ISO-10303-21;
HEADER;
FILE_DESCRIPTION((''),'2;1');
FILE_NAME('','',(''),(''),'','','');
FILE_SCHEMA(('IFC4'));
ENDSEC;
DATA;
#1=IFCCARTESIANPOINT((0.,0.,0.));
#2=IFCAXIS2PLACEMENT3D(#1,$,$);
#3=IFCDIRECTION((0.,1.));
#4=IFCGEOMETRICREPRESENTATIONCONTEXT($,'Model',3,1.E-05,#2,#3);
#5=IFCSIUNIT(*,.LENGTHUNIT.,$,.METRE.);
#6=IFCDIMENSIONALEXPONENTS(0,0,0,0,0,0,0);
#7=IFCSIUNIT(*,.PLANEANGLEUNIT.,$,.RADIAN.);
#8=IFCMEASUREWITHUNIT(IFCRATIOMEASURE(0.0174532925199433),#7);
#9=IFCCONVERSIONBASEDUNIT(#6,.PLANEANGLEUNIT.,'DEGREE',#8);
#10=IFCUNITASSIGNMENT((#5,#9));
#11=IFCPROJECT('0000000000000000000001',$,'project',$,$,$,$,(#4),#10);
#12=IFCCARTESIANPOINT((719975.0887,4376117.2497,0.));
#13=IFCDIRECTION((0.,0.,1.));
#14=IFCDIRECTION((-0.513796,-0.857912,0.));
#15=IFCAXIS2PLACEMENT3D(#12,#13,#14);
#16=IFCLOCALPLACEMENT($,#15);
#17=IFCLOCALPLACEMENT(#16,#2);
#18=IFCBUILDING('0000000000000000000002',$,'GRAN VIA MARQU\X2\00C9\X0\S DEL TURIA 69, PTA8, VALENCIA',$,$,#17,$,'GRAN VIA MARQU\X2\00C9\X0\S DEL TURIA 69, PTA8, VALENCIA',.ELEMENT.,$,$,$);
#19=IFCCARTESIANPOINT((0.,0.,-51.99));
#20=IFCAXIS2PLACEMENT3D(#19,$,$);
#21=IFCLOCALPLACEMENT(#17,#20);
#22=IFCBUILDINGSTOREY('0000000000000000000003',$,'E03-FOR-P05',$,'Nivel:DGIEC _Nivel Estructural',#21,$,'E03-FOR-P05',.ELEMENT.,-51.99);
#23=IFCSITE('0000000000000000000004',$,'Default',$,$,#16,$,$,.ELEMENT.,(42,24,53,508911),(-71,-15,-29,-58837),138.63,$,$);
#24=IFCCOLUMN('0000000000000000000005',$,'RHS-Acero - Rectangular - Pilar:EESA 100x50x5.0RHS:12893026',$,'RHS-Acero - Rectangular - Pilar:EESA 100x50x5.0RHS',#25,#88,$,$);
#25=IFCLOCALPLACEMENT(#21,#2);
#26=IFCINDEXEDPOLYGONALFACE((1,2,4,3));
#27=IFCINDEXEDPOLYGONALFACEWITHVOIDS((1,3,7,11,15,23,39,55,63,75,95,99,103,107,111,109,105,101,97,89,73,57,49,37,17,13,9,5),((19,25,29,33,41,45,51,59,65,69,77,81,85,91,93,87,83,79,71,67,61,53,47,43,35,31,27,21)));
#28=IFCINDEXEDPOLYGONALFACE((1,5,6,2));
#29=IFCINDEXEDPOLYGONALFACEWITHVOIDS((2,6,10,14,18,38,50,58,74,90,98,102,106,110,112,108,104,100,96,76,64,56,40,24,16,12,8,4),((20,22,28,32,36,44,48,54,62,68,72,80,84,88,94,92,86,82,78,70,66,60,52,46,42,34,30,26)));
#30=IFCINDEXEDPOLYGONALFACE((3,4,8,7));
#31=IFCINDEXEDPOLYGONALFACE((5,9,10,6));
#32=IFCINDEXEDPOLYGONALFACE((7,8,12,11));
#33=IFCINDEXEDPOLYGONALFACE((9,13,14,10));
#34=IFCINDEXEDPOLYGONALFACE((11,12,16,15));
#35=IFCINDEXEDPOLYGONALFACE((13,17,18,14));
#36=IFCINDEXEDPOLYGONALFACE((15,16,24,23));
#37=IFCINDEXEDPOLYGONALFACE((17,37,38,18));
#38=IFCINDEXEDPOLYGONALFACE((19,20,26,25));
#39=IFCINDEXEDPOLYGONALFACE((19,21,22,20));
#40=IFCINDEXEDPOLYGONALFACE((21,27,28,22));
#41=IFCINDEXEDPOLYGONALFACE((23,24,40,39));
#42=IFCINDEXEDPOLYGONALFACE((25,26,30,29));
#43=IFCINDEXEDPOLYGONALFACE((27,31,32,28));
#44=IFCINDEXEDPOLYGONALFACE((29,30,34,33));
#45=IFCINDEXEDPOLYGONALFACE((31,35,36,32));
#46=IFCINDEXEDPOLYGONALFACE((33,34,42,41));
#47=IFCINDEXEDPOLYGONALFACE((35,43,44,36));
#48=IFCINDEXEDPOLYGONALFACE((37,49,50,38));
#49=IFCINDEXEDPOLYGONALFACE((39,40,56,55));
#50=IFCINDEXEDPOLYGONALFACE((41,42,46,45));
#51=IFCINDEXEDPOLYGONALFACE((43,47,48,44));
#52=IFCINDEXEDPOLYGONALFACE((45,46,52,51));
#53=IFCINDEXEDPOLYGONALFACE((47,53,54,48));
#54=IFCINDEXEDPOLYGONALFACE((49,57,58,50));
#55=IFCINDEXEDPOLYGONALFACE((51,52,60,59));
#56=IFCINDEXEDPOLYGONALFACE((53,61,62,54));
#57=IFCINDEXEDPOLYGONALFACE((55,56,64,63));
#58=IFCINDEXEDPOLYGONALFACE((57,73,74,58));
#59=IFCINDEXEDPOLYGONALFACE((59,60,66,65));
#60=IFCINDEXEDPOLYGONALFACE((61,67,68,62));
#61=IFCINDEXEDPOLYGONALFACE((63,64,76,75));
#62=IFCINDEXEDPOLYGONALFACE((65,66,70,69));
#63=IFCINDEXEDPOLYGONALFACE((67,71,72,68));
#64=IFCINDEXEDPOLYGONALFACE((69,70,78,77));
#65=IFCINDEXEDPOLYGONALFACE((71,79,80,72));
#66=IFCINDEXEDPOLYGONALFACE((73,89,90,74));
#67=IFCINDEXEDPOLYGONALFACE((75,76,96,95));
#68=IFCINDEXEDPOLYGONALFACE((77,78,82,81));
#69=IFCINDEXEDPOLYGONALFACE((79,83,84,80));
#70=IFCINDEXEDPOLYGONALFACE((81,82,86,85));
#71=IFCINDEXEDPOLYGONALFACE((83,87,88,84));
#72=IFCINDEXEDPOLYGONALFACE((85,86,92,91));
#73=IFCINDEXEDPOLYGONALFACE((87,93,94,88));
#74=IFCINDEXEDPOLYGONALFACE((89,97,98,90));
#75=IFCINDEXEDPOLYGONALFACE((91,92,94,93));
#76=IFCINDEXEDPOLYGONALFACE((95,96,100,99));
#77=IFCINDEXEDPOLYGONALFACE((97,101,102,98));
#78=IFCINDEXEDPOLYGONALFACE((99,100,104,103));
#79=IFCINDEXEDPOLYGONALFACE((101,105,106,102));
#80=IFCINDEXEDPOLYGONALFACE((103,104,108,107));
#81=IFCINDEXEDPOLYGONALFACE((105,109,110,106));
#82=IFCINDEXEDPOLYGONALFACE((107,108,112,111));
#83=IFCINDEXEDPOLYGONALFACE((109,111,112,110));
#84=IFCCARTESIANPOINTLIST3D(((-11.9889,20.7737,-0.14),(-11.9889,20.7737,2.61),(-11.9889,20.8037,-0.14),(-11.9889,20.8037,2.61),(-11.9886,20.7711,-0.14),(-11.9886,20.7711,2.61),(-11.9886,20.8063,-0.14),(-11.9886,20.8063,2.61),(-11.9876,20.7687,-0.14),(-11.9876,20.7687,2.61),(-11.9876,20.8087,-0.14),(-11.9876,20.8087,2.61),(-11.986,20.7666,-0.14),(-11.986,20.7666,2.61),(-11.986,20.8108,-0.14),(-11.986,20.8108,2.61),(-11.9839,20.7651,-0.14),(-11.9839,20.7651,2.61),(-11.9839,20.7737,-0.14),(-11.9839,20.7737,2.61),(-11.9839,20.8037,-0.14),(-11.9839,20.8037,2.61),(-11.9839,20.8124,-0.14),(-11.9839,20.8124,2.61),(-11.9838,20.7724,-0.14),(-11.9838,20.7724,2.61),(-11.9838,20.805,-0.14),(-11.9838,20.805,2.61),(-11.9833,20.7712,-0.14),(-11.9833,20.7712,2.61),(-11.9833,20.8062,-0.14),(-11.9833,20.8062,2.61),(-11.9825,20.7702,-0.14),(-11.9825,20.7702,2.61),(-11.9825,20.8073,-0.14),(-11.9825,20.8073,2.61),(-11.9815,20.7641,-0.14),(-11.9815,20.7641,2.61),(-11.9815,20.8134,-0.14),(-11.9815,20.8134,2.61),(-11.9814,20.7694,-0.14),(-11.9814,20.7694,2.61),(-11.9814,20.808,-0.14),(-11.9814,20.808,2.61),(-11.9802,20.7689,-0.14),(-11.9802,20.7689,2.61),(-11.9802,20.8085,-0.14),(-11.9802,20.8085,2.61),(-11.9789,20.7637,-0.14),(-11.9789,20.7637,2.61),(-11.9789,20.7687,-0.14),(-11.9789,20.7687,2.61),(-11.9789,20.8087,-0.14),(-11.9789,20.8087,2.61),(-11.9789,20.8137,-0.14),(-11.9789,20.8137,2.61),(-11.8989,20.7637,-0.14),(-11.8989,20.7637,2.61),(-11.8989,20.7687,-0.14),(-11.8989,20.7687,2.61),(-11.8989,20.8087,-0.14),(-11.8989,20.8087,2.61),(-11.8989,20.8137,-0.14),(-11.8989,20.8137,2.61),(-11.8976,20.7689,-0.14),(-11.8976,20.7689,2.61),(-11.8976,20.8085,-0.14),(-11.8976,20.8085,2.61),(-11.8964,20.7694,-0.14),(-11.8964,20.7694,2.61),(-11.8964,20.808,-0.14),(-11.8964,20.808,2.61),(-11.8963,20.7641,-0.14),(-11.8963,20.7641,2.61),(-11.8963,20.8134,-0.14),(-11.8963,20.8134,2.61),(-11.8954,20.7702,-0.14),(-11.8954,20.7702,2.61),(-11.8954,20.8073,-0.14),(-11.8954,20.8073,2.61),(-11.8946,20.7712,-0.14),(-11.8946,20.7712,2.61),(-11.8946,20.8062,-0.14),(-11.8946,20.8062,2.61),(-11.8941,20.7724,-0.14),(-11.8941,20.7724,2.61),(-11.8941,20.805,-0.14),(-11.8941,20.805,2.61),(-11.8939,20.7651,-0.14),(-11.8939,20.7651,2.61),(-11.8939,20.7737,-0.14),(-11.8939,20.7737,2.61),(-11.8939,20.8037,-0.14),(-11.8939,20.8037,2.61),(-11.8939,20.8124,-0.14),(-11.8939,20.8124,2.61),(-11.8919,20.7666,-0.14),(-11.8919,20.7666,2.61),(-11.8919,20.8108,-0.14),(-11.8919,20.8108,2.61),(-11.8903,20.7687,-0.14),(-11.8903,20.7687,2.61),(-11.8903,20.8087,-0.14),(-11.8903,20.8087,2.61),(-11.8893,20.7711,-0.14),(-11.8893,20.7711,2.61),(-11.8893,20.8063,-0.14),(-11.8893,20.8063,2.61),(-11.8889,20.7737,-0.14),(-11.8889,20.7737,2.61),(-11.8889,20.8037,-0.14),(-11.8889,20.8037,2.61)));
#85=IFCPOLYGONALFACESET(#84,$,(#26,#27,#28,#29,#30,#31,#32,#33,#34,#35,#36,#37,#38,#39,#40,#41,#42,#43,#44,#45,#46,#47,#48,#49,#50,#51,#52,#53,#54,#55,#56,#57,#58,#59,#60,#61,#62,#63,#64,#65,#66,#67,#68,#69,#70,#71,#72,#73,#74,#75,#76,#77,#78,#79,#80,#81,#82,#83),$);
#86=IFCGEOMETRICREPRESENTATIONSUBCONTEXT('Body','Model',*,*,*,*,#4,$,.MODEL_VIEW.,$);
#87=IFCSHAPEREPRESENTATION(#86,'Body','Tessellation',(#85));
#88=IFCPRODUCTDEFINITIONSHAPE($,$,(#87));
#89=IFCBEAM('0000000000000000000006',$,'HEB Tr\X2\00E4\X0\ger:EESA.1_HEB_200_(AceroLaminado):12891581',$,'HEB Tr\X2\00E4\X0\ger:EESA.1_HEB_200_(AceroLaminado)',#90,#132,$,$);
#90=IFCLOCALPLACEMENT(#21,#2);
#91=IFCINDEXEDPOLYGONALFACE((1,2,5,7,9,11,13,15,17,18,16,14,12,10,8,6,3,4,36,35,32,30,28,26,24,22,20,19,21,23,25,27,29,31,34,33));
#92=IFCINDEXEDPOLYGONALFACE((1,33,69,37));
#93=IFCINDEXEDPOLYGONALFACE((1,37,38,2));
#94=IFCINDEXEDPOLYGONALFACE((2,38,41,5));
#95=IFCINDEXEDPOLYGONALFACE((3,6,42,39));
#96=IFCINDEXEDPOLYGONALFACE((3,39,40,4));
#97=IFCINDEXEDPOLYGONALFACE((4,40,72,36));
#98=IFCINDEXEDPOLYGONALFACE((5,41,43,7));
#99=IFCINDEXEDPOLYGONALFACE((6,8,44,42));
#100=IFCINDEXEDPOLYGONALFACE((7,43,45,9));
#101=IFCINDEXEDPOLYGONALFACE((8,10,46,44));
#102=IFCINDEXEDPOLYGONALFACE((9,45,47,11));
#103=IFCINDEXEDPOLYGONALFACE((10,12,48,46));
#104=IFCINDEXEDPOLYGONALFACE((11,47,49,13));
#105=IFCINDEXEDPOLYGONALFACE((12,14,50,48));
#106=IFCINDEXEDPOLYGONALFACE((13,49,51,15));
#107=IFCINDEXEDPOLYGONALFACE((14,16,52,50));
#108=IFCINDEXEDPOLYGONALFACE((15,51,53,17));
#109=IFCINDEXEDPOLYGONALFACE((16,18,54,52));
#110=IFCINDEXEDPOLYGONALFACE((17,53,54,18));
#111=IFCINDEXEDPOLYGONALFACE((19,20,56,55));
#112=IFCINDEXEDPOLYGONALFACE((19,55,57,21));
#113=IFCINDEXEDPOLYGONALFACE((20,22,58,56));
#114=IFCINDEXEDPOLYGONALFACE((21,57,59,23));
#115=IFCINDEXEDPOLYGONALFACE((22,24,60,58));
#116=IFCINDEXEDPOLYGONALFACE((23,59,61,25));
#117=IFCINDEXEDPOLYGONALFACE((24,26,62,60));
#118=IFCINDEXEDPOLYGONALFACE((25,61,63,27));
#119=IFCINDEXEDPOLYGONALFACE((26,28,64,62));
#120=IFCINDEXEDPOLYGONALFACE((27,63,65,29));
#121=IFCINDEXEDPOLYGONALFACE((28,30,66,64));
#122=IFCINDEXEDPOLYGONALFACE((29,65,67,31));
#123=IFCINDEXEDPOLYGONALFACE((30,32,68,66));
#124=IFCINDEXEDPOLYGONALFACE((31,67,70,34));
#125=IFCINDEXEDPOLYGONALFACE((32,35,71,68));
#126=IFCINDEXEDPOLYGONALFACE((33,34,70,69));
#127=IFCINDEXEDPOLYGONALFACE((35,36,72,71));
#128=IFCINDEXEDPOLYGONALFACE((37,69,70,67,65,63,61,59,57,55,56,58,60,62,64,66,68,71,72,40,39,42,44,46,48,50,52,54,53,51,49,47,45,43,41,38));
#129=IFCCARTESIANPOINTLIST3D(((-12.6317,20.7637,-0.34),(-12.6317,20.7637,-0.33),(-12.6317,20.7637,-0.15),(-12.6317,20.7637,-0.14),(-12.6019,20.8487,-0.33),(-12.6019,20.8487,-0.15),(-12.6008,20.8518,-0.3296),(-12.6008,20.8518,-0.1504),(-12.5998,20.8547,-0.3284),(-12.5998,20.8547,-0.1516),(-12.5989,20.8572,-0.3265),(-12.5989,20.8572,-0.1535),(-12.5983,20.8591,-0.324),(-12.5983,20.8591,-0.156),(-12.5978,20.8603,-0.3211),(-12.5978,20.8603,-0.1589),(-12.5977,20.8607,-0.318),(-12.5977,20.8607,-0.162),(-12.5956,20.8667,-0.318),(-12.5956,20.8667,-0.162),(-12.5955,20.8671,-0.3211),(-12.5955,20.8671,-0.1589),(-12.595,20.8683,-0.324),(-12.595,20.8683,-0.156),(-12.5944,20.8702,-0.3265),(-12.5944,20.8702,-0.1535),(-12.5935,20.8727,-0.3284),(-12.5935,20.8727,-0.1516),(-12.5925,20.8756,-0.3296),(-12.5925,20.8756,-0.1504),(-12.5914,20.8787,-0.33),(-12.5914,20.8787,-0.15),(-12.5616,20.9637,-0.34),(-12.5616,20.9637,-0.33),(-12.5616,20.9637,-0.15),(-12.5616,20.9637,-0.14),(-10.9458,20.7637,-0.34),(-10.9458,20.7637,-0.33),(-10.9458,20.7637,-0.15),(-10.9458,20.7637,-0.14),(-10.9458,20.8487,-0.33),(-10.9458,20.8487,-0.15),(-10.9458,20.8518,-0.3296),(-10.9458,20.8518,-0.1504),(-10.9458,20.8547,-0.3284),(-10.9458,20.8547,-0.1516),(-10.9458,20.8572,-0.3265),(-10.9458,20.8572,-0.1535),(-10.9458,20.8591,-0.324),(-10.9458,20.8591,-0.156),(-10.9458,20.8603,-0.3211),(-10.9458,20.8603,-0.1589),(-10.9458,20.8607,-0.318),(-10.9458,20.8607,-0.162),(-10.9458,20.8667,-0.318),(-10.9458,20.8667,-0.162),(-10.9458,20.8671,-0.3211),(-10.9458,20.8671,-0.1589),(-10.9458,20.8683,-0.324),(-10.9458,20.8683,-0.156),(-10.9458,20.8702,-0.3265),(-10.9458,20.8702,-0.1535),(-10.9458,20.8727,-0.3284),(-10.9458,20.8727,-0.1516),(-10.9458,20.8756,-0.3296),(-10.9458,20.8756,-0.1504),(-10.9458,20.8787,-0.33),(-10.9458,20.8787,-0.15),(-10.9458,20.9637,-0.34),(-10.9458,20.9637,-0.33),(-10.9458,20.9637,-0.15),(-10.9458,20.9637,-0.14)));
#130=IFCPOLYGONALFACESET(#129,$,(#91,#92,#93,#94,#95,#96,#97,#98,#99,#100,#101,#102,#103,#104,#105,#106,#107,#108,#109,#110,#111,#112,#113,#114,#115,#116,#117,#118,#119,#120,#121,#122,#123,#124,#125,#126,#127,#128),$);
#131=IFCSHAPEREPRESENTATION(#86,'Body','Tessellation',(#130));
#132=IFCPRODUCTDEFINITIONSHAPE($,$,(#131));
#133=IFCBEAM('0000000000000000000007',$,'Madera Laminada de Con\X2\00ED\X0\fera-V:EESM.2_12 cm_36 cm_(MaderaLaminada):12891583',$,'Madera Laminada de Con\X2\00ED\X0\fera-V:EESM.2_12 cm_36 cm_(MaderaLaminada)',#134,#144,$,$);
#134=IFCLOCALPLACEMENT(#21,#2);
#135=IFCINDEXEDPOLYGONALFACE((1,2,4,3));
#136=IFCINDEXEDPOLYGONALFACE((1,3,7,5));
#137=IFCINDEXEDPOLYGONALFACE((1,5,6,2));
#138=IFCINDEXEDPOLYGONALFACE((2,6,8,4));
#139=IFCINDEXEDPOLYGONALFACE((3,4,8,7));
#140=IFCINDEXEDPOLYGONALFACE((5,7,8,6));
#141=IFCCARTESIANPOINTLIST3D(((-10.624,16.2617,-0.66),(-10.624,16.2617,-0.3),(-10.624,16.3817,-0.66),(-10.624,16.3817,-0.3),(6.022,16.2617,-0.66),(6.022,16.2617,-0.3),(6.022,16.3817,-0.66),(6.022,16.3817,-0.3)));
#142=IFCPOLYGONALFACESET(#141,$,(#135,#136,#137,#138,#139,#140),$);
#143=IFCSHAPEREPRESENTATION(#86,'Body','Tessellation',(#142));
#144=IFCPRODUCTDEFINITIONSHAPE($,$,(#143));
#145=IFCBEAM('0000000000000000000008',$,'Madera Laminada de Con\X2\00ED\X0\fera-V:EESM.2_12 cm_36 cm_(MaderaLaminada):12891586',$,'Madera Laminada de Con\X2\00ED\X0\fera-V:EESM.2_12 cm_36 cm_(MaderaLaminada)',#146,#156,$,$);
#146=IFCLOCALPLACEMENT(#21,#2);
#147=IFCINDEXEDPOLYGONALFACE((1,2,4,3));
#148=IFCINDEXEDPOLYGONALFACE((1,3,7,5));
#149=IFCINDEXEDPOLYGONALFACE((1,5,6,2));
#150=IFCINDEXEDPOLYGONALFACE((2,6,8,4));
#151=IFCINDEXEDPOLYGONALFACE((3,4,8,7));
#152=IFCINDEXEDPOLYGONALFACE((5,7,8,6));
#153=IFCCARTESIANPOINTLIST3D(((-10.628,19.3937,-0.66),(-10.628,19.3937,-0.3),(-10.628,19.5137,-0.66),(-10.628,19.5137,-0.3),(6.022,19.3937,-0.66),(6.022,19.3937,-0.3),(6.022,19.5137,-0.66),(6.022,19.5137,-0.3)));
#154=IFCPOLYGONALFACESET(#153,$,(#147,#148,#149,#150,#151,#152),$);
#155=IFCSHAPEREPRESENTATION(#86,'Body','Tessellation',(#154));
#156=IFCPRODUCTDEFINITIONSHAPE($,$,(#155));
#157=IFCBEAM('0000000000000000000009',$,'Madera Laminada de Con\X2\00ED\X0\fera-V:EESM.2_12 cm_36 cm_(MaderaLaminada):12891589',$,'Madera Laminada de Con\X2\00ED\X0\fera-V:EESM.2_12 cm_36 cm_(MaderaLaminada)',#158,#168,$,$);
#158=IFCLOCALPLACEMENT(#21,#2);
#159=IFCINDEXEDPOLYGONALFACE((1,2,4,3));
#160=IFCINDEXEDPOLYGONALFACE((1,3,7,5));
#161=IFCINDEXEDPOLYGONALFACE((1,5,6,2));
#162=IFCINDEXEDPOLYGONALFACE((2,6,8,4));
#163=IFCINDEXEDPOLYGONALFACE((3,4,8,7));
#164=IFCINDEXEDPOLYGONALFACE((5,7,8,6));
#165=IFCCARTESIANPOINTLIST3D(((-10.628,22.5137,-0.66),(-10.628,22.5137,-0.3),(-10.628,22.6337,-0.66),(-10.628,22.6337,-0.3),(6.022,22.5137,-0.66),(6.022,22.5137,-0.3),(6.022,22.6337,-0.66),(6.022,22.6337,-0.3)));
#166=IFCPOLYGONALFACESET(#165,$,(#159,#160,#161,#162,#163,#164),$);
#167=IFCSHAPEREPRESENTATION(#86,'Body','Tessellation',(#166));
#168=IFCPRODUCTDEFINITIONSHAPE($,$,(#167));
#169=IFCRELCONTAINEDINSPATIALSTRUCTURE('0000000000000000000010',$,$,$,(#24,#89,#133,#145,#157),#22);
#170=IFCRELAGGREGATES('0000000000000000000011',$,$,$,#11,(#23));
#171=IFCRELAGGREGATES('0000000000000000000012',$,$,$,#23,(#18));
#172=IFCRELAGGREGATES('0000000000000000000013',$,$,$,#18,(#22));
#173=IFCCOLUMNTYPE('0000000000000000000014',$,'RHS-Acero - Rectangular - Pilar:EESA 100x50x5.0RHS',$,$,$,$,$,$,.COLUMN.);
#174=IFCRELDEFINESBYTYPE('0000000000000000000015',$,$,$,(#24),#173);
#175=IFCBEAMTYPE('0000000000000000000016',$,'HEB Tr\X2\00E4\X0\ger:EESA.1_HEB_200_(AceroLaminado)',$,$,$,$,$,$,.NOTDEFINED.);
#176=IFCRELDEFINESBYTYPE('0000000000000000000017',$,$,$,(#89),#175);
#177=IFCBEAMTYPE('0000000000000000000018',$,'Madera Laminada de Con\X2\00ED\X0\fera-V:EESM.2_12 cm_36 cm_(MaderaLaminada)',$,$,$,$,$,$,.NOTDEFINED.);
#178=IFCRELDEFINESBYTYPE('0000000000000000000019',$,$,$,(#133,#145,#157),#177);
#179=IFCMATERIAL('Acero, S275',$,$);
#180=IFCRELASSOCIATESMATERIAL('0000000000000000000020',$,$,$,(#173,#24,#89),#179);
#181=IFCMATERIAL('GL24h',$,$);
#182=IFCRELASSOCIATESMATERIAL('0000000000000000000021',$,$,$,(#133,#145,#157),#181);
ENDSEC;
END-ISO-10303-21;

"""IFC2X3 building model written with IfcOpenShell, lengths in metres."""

from ifc_helpers import new_model, entity, si_unit, converted_unit, direction, frame, frame_2d, origin, place, context, subcontext, project, spatial, polyline, circle_curve, parameter, trimmed, segment, composite_curve, rectangle, i_section, outline, extrude, clip, halfspace, source, transform, mapped, material, type_object, type_shapes, element, save


model = new_model("IFC2X3")

# Units and contexts
model_context = context("Model", 3, precision=1e-05, world=origin(), true_north=direction((0.0, 1.0)))
body_context = subcontext(model_context, "Body", "Model", "MODEL_VIEW")
ifc_project = project(units=[si_unit("LENGTHUNIT", "METRE"), converted_unit("PLANEANGLEUNIT", "DEGREE", entity("IfcRatioMeasure", 0.0174532925199433), si_unit("PLANEANGLEUNIT", "RADIAN"), dimensions=[0, 0, 0, 0, 0, 0, 0])], contexts=[model_context])

# Site, building, storey
site_placement = place(None, frame((719975.0887, 4376117.2497, 0.0), z_axis=(0.0, 0.0, 1.0), x_axis=(-0.513796, -0.857912, 0.0)))
site = spatial("IfcSite", under=ifc_project, at=site_placement, Name="Default", CompositionType="ELEMENT", RefLatitude=(42, 24, 53, 508911), RefLongitude=(-71, -15, -29, -58837), RefElevation=138.63)
building_placement = place(site_placement, origin())
building = spatial("IfcBuilding", under=site, at=building_placement, Name="GRAN VIA MARQUÉS DEL TURIA 69, PTA8, VALENCIA", LongName="GRAN VIA MARQUÉS DEL TURIA 69, PTA8, VALENCIA", CompositionType="ELEMENT")
storey_placement = place(building_placement, frame((0.0, 0.0, -51.99)))
storey = spatial("IfcBuildingStorey", under=building, at=storey_placement, Name="E03-FOR-P05", ObjectType="Nivel:DGIEC _Nivel Estructural", LongName="E03-FOR-P05", CompositionType="ELEMENT", Elevation=-51.99)

# Column
ifc_material_1 = material(Name="GL24h")
ifc_material_2 = material(Name="Acero, S275")
column_type_1 = type_object("IfcColumnType", Name="RHS-Acero - Rectangular - Pilar:EESA 100x50x5.0RHS", PredefinedType="COLUMN", material=ifc_material_2)
shared_shape_1 = source(origin(), body_context, "Body", "SweptSolid", [
    extrude(outline(composite_curve([segment(polyline([(-0.015, -0.05), (0.015, -0.05)]), True, "CONTINUOUS"), segment(trimmed(circle_curve(frame_2d((0.015, -0.04), x_axis=(-1.0, 0.0)), 0.01), [parameter(90.0)], [parameter(180.0)], True, "PARAMETER"), True, "CONTINUOUS"), segment(polyline([(0.025, -0.04), (0.025, 0.04)]), True, "CONTINUOUS"), segment(trimmed(circle_curve(frame_2d((0.015, 0.04), x_axis=(-1.0, 0.0)), 0.01), [parameter(180.0)], [parameter(270.0)], True, "PARAMETER"), True, "CONTINUOUS"), segment(polyline([(0.015, 0.05), (-0.015, 0.05)]), True, "CONTINUOUS"), segment(trimmed(circle_curve(frame_2d((-0.015, 0.04), x_axis=(-1.0, 0.0)), 0.01), [parameter(270.0)], [parameter(360.0)], True, "PARAMETER"), True, "CONTINUOUS"), segment(polyline([(-0.025, 0.04), (-0.025, -0.04)]), True, "CONTINUOUS"), segment(trimmed(circle_curve(frame_2d((-0.015, -0.04), x_axis=(-1.0, 0.0)), 0.01), [parameter(360.0)], [parameter(90.0)], True, "PARAMETER"), True, "CONTINUOUS")], self_intersect=False), holes=[composite_curve([segment(trimmed(circle_curve(frame_2d((-0.015, -0.04), x_axis=(-1.0, 0.0)), 0.005), [parameter(0.0)], [parameter(90.0)], True, "PARAMETER"), False, "CONTINUOUS"), segment(polyline([(-0.02, -0.04), (-0.02, 0.04)]), True, "CONTINUOUS"), segment(trimmed(circle_curve(frame_2d((-0.015, 0.04), x_axis=(-1.0, 0.0)), 0.005), [parameter(270.0)], [parameter(0.0)], True, "PARAMETER"), False, "CONTINUOUS"), segment(polyline([(-0.015, 0.045), (0.015, 0.045)]), True, "CONTINUOUS"), segment(trimmed(circle_curve(frame_2d((0.015, 0.04), x_axis=(-1.0, 0.0)), 0.005), [parameter(180.0)], [parameter(270.0)], True, "PARAMETER"), False, "CONTINUOUS"), segment(polyline([(0.02, 0.04), (0.02, -0.04)]), True, "CONTINUOUS"), segment(trimmed(circle_curve(frame_2d((0.015, -0.04), x_axis=(-1.0, 0.0)), 0.005), [parameter(90.0)], [parameter(180.0)], True, "PARAMETER"), False, "CONTINUOUS"), segment(polyline([(0.015, -0.045), (-0.015, -0.045)]), True, "CONTINUOUS")], self_intersect=False)]), frame((0.0, 0.0, -52.13), z_axis=(0.0, 0.0, 1.0), x_axis=(-1.0, 0.0, 0.0)), (0.0, 0.0, 1.0), 2.75),
])
type_shapes(column_type_1, [shared_shape_1])
column_placement = place(storey_placement, frame((-11.9389, 20.7887, 51.99), z_axis=(0.0, 0.0, 1.0), x_axis=(0.0, 1.0, 0.0)))
element("IfcColumn", 1, at=column_placement, inside=storey, type_object=column_type_1, material=ifc_material_2, Name="RHS-Acero - Rectangular - Pilar:EESA 100x50x5.0RHS:12893026", ObjectType="RHS-Acero - Rectangular - Pilar:EESA 100x50x5.0RHS", context=body_context, shape_type="MappedRepresentation", body=[
    mapped(shared_shape_1, transform((0.0, 0.0, 0.0), scale=1.0)),
])

# Beams
beam_type_1 = type_object("IfcBeamType", Name="HEB Träger:EESA.1_HEB_200_(AceroLaminado)", PredefinedType="NOTDEFINED")
beam_1_placement = place(storey_placement, frame((-10.9458, 20.8637, 0.0), z_axis=(0.0, 0.0, 1.0), x_axis=(-1.0, 0.0, 0.0)))
element("IfcBeam", 2, at=beam_1_placement, inside=storey, type_object=beam_type_1, material=ifc_material_2, Name="HEB Träger:EESA.1_HEB_200_(AceroLaminado):12891581", ObjectType="HEB Träger:EESA.1_HEB_200_(AceroLaminado)", context=body_context, shape_type="Clipping", body=[
    clip(extrude(i_section(OverallWidth=0.2, OverallDepth=0.2, WebThickness=0.006, FlangeThickness=0.01, FilletRadius=0.012, at=frame_2d((0.0, 0.0), x_axis=(0.0, 1.0))), frame((0.0, 0.0, -0.24), z_axis=(1.0, 0.0, 0.0), x_axis=(0.0, 0.0, -1.0)), (0.0, 0.0, 1.0), 1.6859), halfspace(frame((1.6158, -0.1, -1.9968), z_axis=(0.943797, -0.330527, 0.0), x_axis=(0.0, 0.0, 1.0)), False)),
])
beam_type_2 = type_object("IfcBeamType", Name="Madera Laminada de Conífera-V:EESM.2_12 cm_36 cm_(MaderaLaminada)", PredefinedType="NOTDEFINED")
beam_2_placement = place(storey_placement, frame((-10.624, 16.3217, 0.0)))
element("IfcBeam", 3, at=beam_2_placement, inside=storey, type_object=beam_type_2, material=ifc_material_1, Name="Madera Laminada de Conífera-V:EESM.2_12 cm_36 cm_(MaderaLaminada):12891583", ObjectType="Madera Laminada de Conífera-V:EESM.2_12 cm_36 cm_(MaderaLaminada)", context=body_context, shape_type="SweptSolid", body=[
    extrude(rectangle(XDim=0.36, YDim=0.12, at=frame_2d((0.0, 0.0), x_axis=(1.0, 0.0))), frame((0.0, 0.0, -0.48), z_axis=(1.0, 0.0, 0.0), x_axis=(0.0, 0.0, -1.0)), (0.0, 0.0, 1.0), 16.646),
])
beam_3_placement = place(storey_placement, frame((-10.628, 19.4537, 0.0)))
element("IfcBeam", 4, at=beam_3_placement, inside=storey, type_object=beam_type_2, material=ifc_material_1, Name="Madera Laminada de Conífera-V:EESM.2_12 cm_36 cm_(MaderaLaminada):12891586", ObjectType="Madera Laminada de Conífera-V:EESM.2_12 cm_36 cm_(MaderaLaminada)", context=body_context, shape_type="SweptSolid", body=[
    extrude(rectangle(XDim=0.36, YDim=0.12, at=frame_2d((0.0, 0.0), x_axis=(1.0, 0.0))), frame((0.0, 0.0, -0.48), z_axis=(1.0, 0.0, 0.0), x_axis=(0.0, 0.0, -1.0)), (0.0, 0.0, 1.0), 16.65),
])
beam_4_placement = place(storey_placement, frame((-10.628, 22.5737, 0.0)))
element("IfcBeam", 5, at=beam_4_placement, inside=storey, type_object=beam_type_2, material=ifc_material_1, Name="Madera Laminada de Conífera-V:EESM.2_12 cm_36 cm_(MaderaLaminada):12891589", ObjectType="Madera Laminada de Conífera-V:EESM.2_12 cm_36 cm_(MaderaLaminada)", context=body_context, shape_type="SweptSolid", body=[
    extrude(rectangle(XDim=0.36, YDim=0.12, at=frame_2d((0.0, 0.0), x_axis=(1.0, 0.0))), frame((0.0, 0.0, -0.48), z_axis=(1.0, 0.0, 0.0), x_axis=(0.0, 0.0, -1.0)), (0.0, 0.0, 1.0), 16.65),
])

save(model, "model.ifc")
